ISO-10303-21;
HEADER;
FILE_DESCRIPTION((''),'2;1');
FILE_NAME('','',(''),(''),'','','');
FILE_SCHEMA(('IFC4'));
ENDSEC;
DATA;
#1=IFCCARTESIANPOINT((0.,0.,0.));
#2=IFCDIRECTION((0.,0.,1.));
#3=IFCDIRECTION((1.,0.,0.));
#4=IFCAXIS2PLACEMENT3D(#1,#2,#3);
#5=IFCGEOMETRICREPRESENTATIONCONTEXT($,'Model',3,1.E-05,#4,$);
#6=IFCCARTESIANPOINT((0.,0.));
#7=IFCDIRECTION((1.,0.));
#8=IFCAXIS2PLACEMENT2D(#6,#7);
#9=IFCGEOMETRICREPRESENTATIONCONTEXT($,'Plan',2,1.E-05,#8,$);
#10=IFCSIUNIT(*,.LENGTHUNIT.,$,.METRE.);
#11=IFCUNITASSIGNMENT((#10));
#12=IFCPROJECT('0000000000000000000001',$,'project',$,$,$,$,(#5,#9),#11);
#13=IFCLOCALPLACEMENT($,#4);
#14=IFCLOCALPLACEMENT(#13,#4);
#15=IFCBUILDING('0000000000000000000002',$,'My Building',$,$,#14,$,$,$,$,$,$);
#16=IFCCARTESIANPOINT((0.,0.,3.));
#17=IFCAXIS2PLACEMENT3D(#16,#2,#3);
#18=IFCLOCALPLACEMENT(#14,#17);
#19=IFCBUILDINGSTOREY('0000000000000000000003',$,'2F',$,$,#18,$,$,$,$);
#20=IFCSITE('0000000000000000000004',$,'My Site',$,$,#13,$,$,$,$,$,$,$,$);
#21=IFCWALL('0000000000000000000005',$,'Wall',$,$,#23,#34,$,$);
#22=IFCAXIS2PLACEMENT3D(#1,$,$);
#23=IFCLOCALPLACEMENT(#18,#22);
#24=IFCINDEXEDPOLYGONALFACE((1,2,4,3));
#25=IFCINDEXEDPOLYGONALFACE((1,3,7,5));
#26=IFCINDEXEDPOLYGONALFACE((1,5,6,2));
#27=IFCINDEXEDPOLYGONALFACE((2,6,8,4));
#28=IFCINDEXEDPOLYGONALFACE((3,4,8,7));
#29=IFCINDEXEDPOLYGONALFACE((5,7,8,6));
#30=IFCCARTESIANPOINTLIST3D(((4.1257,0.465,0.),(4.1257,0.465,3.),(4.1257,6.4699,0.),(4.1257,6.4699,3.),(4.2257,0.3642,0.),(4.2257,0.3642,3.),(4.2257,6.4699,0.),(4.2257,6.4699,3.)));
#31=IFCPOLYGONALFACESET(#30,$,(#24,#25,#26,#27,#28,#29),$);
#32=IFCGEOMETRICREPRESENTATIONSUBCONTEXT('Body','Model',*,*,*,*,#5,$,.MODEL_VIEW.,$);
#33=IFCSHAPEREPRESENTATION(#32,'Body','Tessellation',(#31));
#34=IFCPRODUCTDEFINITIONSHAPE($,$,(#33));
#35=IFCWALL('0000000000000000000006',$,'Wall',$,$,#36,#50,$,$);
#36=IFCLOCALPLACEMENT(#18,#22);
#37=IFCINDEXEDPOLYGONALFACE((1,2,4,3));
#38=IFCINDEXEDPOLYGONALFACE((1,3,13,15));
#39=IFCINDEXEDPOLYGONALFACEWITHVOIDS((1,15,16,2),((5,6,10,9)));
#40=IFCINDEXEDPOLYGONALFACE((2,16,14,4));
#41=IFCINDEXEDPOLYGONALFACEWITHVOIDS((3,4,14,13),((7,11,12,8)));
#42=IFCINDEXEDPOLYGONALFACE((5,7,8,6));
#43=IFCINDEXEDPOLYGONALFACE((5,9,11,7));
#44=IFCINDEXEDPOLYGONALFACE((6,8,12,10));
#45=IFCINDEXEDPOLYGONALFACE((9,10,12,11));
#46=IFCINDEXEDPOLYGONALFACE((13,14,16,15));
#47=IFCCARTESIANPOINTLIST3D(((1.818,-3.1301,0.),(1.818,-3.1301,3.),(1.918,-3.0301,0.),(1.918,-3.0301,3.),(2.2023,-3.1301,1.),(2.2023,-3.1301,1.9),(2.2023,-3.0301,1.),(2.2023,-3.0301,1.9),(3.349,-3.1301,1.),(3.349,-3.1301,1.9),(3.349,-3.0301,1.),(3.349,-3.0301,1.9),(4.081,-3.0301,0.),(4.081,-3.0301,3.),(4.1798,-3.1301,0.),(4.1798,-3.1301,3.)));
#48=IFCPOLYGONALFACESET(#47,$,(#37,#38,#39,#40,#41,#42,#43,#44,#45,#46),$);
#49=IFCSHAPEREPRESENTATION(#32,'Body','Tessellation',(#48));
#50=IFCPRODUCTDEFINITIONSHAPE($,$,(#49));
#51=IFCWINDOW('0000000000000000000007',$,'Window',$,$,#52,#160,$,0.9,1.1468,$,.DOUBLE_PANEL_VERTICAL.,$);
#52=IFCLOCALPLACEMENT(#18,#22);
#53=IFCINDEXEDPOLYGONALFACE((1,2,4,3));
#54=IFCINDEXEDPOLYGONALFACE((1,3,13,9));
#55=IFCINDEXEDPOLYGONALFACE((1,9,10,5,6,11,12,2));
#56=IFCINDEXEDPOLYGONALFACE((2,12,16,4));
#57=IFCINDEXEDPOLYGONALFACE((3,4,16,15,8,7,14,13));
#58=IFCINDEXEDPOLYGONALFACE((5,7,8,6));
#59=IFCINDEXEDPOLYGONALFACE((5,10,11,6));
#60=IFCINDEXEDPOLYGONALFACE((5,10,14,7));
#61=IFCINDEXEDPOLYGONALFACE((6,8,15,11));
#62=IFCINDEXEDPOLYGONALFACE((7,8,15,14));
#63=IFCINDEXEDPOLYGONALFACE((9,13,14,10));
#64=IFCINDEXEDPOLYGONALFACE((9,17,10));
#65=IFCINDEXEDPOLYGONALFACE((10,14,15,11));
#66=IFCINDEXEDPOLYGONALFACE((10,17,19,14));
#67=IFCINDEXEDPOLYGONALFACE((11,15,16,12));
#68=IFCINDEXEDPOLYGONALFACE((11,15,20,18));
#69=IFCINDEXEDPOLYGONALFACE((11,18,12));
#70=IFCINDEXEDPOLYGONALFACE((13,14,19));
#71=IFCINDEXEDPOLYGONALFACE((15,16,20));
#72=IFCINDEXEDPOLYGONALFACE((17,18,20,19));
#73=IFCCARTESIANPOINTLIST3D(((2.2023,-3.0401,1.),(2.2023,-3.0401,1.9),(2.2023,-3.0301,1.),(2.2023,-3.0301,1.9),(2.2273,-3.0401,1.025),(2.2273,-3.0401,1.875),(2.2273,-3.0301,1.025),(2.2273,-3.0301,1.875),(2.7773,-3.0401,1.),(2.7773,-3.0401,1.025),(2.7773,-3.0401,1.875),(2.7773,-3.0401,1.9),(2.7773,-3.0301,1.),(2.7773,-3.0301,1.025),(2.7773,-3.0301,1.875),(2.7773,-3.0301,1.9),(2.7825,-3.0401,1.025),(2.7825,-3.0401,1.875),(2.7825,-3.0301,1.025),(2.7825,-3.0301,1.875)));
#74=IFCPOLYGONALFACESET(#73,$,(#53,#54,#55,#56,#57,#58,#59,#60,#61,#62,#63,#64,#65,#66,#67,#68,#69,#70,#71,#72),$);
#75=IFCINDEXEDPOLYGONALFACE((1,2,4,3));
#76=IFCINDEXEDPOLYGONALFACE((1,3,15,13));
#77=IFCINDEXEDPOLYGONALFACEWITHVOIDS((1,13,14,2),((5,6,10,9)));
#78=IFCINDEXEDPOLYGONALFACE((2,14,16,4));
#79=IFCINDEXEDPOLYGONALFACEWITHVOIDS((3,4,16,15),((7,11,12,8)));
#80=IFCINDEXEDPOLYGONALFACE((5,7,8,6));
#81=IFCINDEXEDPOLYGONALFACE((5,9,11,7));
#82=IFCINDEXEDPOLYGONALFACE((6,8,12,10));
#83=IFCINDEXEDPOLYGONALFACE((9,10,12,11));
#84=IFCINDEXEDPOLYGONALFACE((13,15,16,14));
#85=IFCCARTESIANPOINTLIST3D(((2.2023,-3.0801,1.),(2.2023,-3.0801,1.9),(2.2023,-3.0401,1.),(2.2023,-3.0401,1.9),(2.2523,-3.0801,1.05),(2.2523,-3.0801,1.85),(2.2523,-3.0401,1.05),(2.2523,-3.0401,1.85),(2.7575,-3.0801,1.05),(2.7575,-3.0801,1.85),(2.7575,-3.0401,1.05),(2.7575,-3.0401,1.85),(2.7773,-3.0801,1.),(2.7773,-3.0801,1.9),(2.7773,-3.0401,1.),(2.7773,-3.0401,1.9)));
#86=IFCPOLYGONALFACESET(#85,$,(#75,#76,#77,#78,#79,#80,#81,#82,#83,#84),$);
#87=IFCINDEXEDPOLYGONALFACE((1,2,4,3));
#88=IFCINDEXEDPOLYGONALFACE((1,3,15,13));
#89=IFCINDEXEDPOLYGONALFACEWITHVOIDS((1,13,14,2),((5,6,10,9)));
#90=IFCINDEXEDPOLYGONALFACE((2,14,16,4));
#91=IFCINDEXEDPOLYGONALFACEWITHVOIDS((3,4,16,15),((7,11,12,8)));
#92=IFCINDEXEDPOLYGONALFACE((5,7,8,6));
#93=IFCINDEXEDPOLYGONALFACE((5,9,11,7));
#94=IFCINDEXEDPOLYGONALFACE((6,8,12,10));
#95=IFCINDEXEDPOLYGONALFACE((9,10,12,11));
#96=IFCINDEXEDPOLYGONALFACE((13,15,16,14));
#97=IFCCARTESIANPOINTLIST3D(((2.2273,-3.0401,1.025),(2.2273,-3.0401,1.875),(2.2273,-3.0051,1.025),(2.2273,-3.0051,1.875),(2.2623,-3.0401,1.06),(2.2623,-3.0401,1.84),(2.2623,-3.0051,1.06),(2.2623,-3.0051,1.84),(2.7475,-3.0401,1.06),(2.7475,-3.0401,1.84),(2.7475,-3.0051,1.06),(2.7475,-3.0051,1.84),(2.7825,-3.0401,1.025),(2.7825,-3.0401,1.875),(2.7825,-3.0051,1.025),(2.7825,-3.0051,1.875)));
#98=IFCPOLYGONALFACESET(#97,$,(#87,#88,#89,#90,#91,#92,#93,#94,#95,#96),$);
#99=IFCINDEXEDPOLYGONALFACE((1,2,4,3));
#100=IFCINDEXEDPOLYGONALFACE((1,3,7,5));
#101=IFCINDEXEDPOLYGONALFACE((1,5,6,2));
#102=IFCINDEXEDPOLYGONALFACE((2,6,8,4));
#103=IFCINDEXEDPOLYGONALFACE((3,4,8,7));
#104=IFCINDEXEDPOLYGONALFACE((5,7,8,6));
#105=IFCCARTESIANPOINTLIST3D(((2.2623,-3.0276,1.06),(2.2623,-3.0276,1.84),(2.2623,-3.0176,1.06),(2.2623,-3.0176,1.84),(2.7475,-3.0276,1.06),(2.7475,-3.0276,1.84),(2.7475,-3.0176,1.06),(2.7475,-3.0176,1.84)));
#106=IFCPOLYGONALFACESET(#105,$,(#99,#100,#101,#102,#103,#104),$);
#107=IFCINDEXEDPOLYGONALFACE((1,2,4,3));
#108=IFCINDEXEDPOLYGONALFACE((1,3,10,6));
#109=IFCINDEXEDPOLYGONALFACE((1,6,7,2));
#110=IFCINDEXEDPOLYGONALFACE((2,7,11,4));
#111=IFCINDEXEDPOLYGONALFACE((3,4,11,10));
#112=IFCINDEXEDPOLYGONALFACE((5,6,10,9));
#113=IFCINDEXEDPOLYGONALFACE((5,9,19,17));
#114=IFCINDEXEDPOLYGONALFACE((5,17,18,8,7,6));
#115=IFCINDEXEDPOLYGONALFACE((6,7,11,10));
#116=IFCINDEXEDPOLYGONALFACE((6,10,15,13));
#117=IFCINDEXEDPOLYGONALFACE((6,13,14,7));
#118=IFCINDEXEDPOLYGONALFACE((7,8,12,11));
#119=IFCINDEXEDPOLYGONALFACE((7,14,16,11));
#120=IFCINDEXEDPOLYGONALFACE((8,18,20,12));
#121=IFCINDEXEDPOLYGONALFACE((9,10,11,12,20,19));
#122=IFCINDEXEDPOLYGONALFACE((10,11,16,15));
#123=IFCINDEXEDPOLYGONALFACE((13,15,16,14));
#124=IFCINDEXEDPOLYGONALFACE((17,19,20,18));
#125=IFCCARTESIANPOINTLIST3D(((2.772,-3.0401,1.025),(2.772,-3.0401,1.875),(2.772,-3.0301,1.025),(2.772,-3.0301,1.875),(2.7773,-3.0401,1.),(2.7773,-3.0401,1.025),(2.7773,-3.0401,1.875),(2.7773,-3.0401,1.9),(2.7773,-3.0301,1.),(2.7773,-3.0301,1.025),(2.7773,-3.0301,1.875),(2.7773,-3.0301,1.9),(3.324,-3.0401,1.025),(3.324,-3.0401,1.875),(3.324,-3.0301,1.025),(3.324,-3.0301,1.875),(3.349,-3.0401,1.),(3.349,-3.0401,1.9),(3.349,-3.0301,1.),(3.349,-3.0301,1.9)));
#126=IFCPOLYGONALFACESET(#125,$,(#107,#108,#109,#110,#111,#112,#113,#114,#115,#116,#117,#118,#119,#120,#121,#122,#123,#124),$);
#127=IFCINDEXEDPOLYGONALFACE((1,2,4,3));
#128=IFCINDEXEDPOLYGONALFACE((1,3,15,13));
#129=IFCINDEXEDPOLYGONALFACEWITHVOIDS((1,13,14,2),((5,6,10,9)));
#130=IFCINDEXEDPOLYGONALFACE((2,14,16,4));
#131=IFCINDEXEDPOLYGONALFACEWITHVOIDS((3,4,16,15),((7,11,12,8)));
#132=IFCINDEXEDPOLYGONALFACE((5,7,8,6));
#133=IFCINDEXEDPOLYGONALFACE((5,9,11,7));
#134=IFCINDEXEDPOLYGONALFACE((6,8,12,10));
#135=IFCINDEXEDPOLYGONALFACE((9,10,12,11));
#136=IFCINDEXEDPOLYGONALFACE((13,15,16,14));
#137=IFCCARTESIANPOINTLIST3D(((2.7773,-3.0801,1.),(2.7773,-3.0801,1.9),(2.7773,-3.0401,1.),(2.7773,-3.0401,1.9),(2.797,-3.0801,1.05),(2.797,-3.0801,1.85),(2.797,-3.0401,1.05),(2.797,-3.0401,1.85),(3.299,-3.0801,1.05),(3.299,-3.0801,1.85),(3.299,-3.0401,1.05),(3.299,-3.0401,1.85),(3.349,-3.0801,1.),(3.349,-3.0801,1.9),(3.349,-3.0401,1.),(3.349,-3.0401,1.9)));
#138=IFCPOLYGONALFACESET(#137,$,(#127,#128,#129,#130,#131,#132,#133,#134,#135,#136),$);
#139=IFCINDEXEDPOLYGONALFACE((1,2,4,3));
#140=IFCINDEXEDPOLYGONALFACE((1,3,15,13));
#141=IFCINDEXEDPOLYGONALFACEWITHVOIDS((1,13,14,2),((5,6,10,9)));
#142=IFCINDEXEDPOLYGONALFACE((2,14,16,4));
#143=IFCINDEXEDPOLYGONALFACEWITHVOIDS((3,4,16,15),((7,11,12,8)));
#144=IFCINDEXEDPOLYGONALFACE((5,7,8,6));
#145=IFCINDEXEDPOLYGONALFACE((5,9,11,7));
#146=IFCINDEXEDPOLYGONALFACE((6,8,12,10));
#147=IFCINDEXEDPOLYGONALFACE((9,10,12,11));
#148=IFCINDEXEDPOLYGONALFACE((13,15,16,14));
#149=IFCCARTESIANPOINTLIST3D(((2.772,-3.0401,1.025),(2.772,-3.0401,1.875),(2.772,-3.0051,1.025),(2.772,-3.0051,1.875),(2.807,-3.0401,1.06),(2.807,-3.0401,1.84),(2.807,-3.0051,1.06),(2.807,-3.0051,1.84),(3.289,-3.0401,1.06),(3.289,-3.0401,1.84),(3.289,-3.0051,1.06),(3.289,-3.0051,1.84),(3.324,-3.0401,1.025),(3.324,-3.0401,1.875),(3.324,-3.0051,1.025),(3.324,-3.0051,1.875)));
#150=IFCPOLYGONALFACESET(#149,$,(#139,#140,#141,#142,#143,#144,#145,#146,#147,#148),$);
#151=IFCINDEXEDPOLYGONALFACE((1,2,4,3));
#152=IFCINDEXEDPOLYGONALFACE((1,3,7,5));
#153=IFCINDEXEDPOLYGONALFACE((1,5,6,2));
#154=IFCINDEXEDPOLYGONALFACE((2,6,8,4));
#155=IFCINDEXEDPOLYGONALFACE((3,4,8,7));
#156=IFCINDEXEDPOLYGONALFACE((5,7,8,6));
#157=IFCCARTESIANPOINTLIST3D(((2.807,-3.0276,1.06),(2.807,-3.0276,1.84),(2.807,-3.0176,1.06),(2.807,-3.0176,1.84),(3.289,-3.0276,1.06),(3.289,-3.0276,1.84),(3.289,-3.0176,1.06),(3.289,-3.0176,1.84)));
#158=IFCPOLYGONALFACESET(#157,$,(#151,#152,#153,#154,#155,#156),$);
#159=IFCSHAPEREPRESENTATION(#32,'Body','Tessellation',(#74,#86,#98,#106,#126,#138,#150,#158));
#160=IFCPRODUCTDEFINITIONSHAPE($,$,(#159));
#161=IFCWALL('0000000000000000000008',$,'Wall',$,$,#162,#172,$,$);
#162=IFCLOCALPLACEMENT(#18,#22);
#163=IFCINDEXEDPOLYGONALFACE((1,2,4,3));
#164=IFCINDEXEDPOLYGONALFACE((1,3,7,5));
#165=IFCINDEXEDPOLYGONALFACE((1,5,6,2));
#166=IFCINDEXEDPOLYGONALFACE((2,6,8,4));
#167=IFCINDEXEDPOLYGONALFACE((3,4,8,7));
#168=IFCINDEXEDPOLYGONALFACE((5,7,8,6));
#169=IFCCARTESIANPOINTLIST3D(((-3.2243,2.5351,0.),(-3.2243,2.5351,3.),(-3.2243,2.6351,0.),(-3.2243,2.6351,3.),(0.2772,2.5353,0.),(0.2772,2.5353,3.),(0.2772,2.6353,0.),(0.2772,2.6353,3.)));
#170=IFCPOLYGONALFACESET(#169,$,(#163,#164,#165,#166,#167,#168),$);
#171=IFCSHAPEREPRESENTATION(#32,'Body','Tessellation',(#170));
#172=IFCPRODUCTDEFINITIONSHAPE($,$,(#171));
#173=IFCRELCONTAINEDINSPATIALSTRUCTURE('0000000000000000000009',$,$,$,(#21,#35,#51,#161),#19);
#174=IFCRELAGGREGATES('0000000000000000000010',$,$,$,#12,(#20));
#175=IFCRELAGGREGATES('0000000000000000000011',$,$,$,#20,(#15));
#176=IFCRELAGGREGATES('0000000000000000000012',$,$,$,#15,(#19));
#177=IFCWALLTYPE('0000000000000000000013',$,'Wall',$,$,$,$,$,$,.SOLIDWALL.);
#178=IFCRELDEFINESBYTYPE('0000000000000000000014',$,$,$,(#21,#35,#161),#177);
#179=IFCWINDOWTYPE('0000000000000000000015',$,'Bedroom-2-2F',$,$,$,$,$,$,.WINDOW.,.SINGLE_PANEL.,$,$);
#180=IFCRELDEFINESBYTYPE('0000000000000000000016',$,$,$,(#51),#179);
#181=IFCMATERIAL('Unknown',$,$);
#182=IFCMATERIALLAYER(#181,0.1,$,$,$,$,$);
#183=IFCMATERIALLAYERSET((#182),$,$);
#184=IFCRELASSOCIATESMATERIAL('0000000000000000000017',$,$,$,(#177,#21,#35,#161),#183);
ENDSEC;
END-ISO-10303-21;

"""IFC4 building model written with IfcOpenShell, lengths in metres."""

from ifc_helpers import new_model, entity, si_unit, frame, origin_with_axes, origin_2d_with_axis, place, context, subcontext, project, spatial, line, indexed_curve, outline, extrude, shape, source, transform, mapped, material, layer, layer_set, layer_usage, type_object, type_shapes, element, fill, save


model = new_model("IFC4")

# Units and contexts
model_context = context("Model", 3, precision=1e-05, world=origin_with_axes())
plan_context = context("Plan", 2, precision=1e-05, world=origin_2d_with_axis())
body_context_1 = subcontext(model_context, "Body", "Model", "MODEL_VIEW")
body_context_2 = subcontext(plan_context, "Body", "Plan", "PLAN_VIEW")
ifc_project = project(units=[si_unit("LENGTHUNIT", "METRE")], contexts=[model_context, plan_context])

# Site, building, storey
site_placement = place(None, origin_with_axes())
site = spatial("IfcSite", under=ifc_project, at=site_placement, Name="My Site")
building_placement = place(site_placement, origin_with_axes())
building = spatial("IfcBuilding", under=site, at=building_placement, Name="My Building")
storey_placement = place(building_placement, frame((0.0, 0.0, 3.0), z_axis=(0.0, 0.0, 1.0), x_axis=(1.0, 0.0, 0.0)))
storey = spatial("IfcBuildingStorey", under=building, at=storey_placement, Name="2F")

# Shared definitions
ifc_material = material(Name="Unknown")

# Shared definitions
ifc_layer = layer(ifc_material, 0.1)
ifc_layer_set = layer_set([ifc_layer])
wall_type = type_object("IfcWallType", Name="Wall", PredefinedType="SOLIDWALL", material=ifc_layer_set)

# Wall
ifc_layer_usage_1 = layer_usage(ifc_layer_set, "AXIS2", "POSITIVE", 0.0)
wall_1_placement = place(storey_placement, frame((4.2257, 0.3642, 0.0), z_axis=(0.0, 0.0, 1.0), x_axis=(0.0, 1.0, 0.0)))
element("IfcWall", 1, at=wall_1_placement, inside=storey, type_object=wall_type, material=ifc_layer_usage_1, Name="Wall", context=body_context_1, shape_type="SweptSolid", body=[
    extrude(outline(indexed_curve([(0.0, 0.0), (0.1007, 0.1), (6.1056, 0.1), (6.1056, 0.0)], segments=[line(1, 2, 3, 4, 1)])), origin_with_axes(), (0.0, 0.0, 1.0), 3.0),
])

# Wall, opening, window
ifc_layer_usage_2 = layer_usage(ifc_layer_set, "AXIS2", "POSITIVE", 0.0)
wall_2_placement = place(storey_placement, frame((1.818, -3.1301, 0.0), z_axis=(0.0, 0.0, 1.0), x_axis=(1.0, 0.0, 0.0)))
wall_2 = element("IfcWall", 2, at=wall_2_placement, inside=storey, type_object=wall_type, material=ifc_layer_usage_2, Name="Wall", context=body_context_1, shape_type="SweptSolid", body=[
    extrude(outline(indexed_curve([(0.0, 0.0), (0.0999, 0.1), (2.2629, 0.1), (2.3618, 0.0)], segments=[line(1, 2, 3, 4, 1)])), origin_with_axes(), (0.0, 0.0, 1.0), 3.0),
])
shared_shape_1 = source(origin_with_axes(), body_context_1, "Body", "SweptSolid", [
    extrude(outline(indexed_curve([(0.0, 0.0), (1.1468, 0.0), (1.1468, 0.9), (0.0, 0.9)], segments=[line(1, 2, 3, 4, 1)])), frame((0.0, -0.6, 0.0), z_axis=(0.0, -1.0, 0.0), x_axis=(1.0, 0.0, 0.0)), (0.0, 0.0, -1.0), 1.2),
])
opening_1_placement = place(wall_2_placement, frame((0.3842, 0.0, 1.0), z_axis=(0.0, 0.0, 1.0), x_axis=(1.0, 0.0, 0.0)))
opening_1 = element("IfcOpeningElement", 3, at=opening_1_placement, cuts=wall_2, PredefinedType="OPENING", context=body_context_1, shape_type="MappedRepresentation", body=[
    mapped(shared_shape_1, transform((0.0, 0.0, 0.0), x_axis=(1.0, 0.0, 0.0), y_axis=(0.0, 1.0, 0.0), z_axis=(0.0, 0.0, 1.0), scale=1.0)),
])
window_type = type_object("IfcWindowType", Name="Bedroom-2-2F", PartitioningType="SINGLE_PANEL", PredefinedType="WINDOW")
shared_shape_2 = source(origin_with_axes(), body_context_1, "Body", "SweptSolid", [
    extrude(outline(indexed_curve([(0.0, 0.0), (0.575, 0.0), (0.575, 0.9), (0.0, 0.9)], segments=[line(1, 2, 3, 4, 1)]), holes=[indexed_curve([(0.025, 0.025), (0.5803, 0.025), (0.5803, 0.875), (0.025, 0.875)], segments=[line(1, 2, 3, 4, 1)])]), frame((0.0, 0.09, 0.0), z_axis=(0.0, -1.0, 0.0), x_axis=(1.0, 0.0, 0.0)), (0.0, 0.0, -1.0), 0.01),
    extrude(outline(indexed_curve([(0.0, 0.0), (0.575, 0.0), (0.575, 0.9), (0.0, 0.9)], segments=[line(1, 2, 3, 4, 1)]), holes=[indexed_curve([(0.05, 0.05), (0.5553, 0.05), (0.5553, 0.85), (0.05, 0.85)], segments=[line(1, 2, 3, 4, 1)])]), frame((0.0, 0.05, 0.0), z_axis=(0.0, -1.0, 0.0), x_axis=(1.0, 0.0, 0.0)), (0.0, 0.0, -1.0), 0.04),
    extrude(outline(indexed_curve([(0.0, 0.0), (0.5553, 0.0), (0.5553, 0.85), (0.0, 0.85)], segments=[line(1, 2, 3, 4, 1)]), holes=[indexed_curve([(0.035, 0.035), (0.5203, 0.035), (0.5203, 0.815), (0.035, 0.815)], segments=[line(1, 2, 3, 4, 1)])]), frame((0.025, 0.09, 0.025), z_axis=(0.0, -1.0, 0.0), x_axis=(1.0, 0.0, 0.0)), (0.0, 0.0, -1.0), 0.035),
    extrude(outline(indexed_curve([(0.035, 0.035), (0.5203, 0.035), (0.5203, 0.815), (0.035, 0.815)], segments=[line(1, 2, 3, 4, 1)])), frame((0.025, 0.1025, 0.025), z_axis=(0.0, -1.0, 0.0), x_axis=(1.0, 0.0, 0.0)), (0.0, 0.0, -1.0), 0.01),
    extrude(outline(indexed_curve([(0.0, 0.0), (0.5718, 0.0), (0.5718, 0.9), (0.0, 0.9)], segments=[line(1, 2, 3, 4, 1)]), holes=[indexed_curve([(-0.0052, 0.025), (0.5468, 0.025), (0.5468, 0.875), (-0.0052, 0.875)], segments=[line(1, 2, 3, 4, 1)])]), frame((0.575, 0.09, 0.0), z_axis=(0.0, -1.0, 0.0), x_axis=(1.0, 0.0, 0.0)), (0.0, 0.0, -1.0), 0.01),
    extrude(outline(indexed_curve([(0.0, 0.0), (0.5718, 0.0), (0.5718, 0.9), (0.0, 0.9)], segments=[line(1, 2, 3, 4, 1)]), holes=[indexed_curve([(0.0198, 0.05), (0.5218, 0.05), (0.5218, 0.85), (0.0198, 0.85)], segments=[line(1, 2, 3, 4, 1)])]), frame((0.575, 0.05, 0.0), z_axis=(0.0, -1.0, 0.0), x_axis=(1.0, 0.0, 0.0)), (0.0, 0.0, -1.0), 0.04),
    extrude(outline(indexed_curve([(0.0, 0.0), (0.552, 0.0), (0.552, 0.85), (0.0, 0.85)], segments=[line(1, 2, 3, 4, 1)]), holes=[indexed_curve([(0.035, 0.035), (0.517, 0.035), (0.517, 0.815), (0.035, 0.815)], segments=[line(1, 2, 3, 4, 1)])]), frame((0.5698, 0.09, 0.025), z_axis=(0.0, -1.0, 0.0), x_axis=(1.0, 0.0, 0.0)), (0.0, 0.0, -1.0), 0.035),
    extrude(outline(indexed_curve([(0.035, 0.035), (0.517, 0.035), (0.517, 0.815), (0.035, 0.815)], segments=[line(1, 2, 3, 4, 1)])), frame((0.5698, 0.1025, 0.025), z_axis=(0.0, -1.0, 0.0), x_axis=(1.0, 0.0, 0.0)), (0.0, 0.0, -1.0), 0.01),
])
shared_shape_3 = source(origin_with_axes(), body_context_2, "Body", "Curve2D", [
    entity("IfcIndexedPolyCurve", entity("IfcCartesianPointList2D", [[0.05, 0.05], [0.5553, 0.05]])),
    entity("IfcIndexedPolyCurve", entity("IfcCartesianPointList2D", [[0.0, 0.1], [0.025, 0.1], [0.025, 0.09], [0.05, 0.09], [0.05, 0.05], [0.0, 0.05]]), [entity("IfcLineIndex", [1, 2, 3, 4, 5, 6, 1])]),
    entity("IfcIndexedPolyCurve", entity("IfcCartesianPointList2D", [[0.575, 0.1], [0.5803, 0.1], [0.5803, 0.09], [0.5553, 0.09], [0.5553, 0.05], [0.575, 0.05]])),
    entity("IfcIndexedPolyCurve", entity("IfcCartesianPointList2D", [[0.025, 0.09], [0.06, 0.09], [0.06, 0.125], [0.025, 0.125]]), [entity("IfcLineIndex", [1, 2, 3, 4, 1])]),
    entity("IfcIndexedPolyCurve", entity("IfcCartesianPointList2D", [[0.5803, 0.09], [0.5453, 0.09], [0.5453, 0.125], [0.5803, 0.125]]), [entity("IfcLineIndex", [1, 2, 3, 4, 1])]),
    entity("IfcIndexedPolyCurve", entity("IfcCartesianPointList2D", [[0.06, 0.09], [0.5453, 0.09]])),
    entity("IfcIndexedPolyCurve", entity("IfcCartesianPointList2D", [[0.06, 0.125], [0.5453, 0.125]])),
    entity("IfcIndexedPolyCurve", entity("IfcCartesianPointList2D", [[0.06, 0.1075], [0.5453, 0.1075]])),
    entity("IfcIndexedPolyCurve", entity("IfcCartesianPointList2D", [[0.5948, 0.05], [1.0968, 0.05]])),
    entity("IfcIndexedPolyCurve", entity("IfcCartesianPointList2D", [[0.575, 0.1], [0.5698, 0.1], [0.5698, 0.09], [0.5948, 0.09], [0.5948, 0.05], [0.575, 0.05]])),
    entity("IfcIndexedPolyCurve", entity("IfcCartesianPointList2D", [[1.1468, 0.1], [1.1218, 0.1], [1.1218, 0.09], [1.0968, 0.09], [1.0968, 0.05], [1.1468, 0.05]]), [entity("IfcLineIndex", [1, 2, 3, 4, 5, 6, 1])]),
    entity("IfcIndexedPolyCurve", entity("IfcCartesianPointList2D", [[0.5698, 0.09], [0.6048, 0.09], [0.6048, 0.125], [0.5698, 0.125]]), [entity("IfcLineIndex", [1, 2, 3, 4, 1])]),
    entity("IfcIndexedPolyCurve", entity("IfcCartesianPointList2D", [[1.1218, 0.09], [1.0868, 0.09], [1.0868, 0.125], [1.1218, 0.125]]), [entity("IfcLineIndex", [1, 2, 3, 4, 1])]),
    entity("IfcIndexedPolyCurve", entity("IfcCartesianPointList2D", [[0.6048, 0.09], [1.0868, 0.09]])),
    entity("IfcIndexedPolyCurve", entity("IfcCartesianPointList2D", [[0.6048, 0.125], [1.0868, 0.125]])),
    entity("IfcIndexedPolyCurve", entity("IfcCartesianPointList2D", [[0.6048, 0.1075], [1.0868, 0.1075]])),
])
type_shapes(window_type, [shared_shape_2, shared_shape_3])
window_placement = place(opening_1_placement, origin_with_axes())
window = element("IfcWindow", 4, at=window_placement, inside=storey, type_object=window_type, Name="Window", OverallHeight=0.9, OverallWidth=1.1468, PartitioningType="DOUBLE_PANEL_VERTICAL", shapes=[
    shape(body_context_1, "Body", "MappedRepresentation", [mapped(shared_shape_2, transform((0.0, 0.0, 0.0), x_axis=(1.0, 0.0, 0.0), y_axis=(0.0, 1.0, 0.0), z_axis=(0.0, 0.0, 1.0), scale=1.0))]),
    shape(body_context_2, "Body", "MappedRepresentation", [mapped(shared_shape_3, transform((0.0, 0.0, 0.0), x_axis=(1.0, 0.0, 0.0), y_axis=(0.0, 1.0, 0.0), z_axis=(0.0, 0.0, 1.0), scale=1.0))]),
])
fill(opening_1, window)

# Wall
ifc_layer_usage_3 = layer_usage(ifc_layer_set, "AXIS2", "POSITIVE", 0.0)
wall_3_placement = place(storey_placement, frame((-3.2243, 2.5351, 0.0), z_axis=(0.0, 0.0, 1.0), x_axis=(1.0, 0.000051, 0.0)))
element("IfcWall", 5, at=wall_3_placement, inside=storey, type_object=wall_type, material=ifc_layer_usage_3, Name="Wall", context=body_context_1, shape_type="SweptSolid", body=[
    extrude(outline(indexed_curve([(0.0, 0.0), (0.0, 0.1), (3.5015, 0.1), (3.5015, 0.0)], segments=[line(1, 2, 3, 4, 1)])), origin_with_axes(), (0.0, 0.0, 1.0), 3.0),
])

save(model, "model.ifc")
